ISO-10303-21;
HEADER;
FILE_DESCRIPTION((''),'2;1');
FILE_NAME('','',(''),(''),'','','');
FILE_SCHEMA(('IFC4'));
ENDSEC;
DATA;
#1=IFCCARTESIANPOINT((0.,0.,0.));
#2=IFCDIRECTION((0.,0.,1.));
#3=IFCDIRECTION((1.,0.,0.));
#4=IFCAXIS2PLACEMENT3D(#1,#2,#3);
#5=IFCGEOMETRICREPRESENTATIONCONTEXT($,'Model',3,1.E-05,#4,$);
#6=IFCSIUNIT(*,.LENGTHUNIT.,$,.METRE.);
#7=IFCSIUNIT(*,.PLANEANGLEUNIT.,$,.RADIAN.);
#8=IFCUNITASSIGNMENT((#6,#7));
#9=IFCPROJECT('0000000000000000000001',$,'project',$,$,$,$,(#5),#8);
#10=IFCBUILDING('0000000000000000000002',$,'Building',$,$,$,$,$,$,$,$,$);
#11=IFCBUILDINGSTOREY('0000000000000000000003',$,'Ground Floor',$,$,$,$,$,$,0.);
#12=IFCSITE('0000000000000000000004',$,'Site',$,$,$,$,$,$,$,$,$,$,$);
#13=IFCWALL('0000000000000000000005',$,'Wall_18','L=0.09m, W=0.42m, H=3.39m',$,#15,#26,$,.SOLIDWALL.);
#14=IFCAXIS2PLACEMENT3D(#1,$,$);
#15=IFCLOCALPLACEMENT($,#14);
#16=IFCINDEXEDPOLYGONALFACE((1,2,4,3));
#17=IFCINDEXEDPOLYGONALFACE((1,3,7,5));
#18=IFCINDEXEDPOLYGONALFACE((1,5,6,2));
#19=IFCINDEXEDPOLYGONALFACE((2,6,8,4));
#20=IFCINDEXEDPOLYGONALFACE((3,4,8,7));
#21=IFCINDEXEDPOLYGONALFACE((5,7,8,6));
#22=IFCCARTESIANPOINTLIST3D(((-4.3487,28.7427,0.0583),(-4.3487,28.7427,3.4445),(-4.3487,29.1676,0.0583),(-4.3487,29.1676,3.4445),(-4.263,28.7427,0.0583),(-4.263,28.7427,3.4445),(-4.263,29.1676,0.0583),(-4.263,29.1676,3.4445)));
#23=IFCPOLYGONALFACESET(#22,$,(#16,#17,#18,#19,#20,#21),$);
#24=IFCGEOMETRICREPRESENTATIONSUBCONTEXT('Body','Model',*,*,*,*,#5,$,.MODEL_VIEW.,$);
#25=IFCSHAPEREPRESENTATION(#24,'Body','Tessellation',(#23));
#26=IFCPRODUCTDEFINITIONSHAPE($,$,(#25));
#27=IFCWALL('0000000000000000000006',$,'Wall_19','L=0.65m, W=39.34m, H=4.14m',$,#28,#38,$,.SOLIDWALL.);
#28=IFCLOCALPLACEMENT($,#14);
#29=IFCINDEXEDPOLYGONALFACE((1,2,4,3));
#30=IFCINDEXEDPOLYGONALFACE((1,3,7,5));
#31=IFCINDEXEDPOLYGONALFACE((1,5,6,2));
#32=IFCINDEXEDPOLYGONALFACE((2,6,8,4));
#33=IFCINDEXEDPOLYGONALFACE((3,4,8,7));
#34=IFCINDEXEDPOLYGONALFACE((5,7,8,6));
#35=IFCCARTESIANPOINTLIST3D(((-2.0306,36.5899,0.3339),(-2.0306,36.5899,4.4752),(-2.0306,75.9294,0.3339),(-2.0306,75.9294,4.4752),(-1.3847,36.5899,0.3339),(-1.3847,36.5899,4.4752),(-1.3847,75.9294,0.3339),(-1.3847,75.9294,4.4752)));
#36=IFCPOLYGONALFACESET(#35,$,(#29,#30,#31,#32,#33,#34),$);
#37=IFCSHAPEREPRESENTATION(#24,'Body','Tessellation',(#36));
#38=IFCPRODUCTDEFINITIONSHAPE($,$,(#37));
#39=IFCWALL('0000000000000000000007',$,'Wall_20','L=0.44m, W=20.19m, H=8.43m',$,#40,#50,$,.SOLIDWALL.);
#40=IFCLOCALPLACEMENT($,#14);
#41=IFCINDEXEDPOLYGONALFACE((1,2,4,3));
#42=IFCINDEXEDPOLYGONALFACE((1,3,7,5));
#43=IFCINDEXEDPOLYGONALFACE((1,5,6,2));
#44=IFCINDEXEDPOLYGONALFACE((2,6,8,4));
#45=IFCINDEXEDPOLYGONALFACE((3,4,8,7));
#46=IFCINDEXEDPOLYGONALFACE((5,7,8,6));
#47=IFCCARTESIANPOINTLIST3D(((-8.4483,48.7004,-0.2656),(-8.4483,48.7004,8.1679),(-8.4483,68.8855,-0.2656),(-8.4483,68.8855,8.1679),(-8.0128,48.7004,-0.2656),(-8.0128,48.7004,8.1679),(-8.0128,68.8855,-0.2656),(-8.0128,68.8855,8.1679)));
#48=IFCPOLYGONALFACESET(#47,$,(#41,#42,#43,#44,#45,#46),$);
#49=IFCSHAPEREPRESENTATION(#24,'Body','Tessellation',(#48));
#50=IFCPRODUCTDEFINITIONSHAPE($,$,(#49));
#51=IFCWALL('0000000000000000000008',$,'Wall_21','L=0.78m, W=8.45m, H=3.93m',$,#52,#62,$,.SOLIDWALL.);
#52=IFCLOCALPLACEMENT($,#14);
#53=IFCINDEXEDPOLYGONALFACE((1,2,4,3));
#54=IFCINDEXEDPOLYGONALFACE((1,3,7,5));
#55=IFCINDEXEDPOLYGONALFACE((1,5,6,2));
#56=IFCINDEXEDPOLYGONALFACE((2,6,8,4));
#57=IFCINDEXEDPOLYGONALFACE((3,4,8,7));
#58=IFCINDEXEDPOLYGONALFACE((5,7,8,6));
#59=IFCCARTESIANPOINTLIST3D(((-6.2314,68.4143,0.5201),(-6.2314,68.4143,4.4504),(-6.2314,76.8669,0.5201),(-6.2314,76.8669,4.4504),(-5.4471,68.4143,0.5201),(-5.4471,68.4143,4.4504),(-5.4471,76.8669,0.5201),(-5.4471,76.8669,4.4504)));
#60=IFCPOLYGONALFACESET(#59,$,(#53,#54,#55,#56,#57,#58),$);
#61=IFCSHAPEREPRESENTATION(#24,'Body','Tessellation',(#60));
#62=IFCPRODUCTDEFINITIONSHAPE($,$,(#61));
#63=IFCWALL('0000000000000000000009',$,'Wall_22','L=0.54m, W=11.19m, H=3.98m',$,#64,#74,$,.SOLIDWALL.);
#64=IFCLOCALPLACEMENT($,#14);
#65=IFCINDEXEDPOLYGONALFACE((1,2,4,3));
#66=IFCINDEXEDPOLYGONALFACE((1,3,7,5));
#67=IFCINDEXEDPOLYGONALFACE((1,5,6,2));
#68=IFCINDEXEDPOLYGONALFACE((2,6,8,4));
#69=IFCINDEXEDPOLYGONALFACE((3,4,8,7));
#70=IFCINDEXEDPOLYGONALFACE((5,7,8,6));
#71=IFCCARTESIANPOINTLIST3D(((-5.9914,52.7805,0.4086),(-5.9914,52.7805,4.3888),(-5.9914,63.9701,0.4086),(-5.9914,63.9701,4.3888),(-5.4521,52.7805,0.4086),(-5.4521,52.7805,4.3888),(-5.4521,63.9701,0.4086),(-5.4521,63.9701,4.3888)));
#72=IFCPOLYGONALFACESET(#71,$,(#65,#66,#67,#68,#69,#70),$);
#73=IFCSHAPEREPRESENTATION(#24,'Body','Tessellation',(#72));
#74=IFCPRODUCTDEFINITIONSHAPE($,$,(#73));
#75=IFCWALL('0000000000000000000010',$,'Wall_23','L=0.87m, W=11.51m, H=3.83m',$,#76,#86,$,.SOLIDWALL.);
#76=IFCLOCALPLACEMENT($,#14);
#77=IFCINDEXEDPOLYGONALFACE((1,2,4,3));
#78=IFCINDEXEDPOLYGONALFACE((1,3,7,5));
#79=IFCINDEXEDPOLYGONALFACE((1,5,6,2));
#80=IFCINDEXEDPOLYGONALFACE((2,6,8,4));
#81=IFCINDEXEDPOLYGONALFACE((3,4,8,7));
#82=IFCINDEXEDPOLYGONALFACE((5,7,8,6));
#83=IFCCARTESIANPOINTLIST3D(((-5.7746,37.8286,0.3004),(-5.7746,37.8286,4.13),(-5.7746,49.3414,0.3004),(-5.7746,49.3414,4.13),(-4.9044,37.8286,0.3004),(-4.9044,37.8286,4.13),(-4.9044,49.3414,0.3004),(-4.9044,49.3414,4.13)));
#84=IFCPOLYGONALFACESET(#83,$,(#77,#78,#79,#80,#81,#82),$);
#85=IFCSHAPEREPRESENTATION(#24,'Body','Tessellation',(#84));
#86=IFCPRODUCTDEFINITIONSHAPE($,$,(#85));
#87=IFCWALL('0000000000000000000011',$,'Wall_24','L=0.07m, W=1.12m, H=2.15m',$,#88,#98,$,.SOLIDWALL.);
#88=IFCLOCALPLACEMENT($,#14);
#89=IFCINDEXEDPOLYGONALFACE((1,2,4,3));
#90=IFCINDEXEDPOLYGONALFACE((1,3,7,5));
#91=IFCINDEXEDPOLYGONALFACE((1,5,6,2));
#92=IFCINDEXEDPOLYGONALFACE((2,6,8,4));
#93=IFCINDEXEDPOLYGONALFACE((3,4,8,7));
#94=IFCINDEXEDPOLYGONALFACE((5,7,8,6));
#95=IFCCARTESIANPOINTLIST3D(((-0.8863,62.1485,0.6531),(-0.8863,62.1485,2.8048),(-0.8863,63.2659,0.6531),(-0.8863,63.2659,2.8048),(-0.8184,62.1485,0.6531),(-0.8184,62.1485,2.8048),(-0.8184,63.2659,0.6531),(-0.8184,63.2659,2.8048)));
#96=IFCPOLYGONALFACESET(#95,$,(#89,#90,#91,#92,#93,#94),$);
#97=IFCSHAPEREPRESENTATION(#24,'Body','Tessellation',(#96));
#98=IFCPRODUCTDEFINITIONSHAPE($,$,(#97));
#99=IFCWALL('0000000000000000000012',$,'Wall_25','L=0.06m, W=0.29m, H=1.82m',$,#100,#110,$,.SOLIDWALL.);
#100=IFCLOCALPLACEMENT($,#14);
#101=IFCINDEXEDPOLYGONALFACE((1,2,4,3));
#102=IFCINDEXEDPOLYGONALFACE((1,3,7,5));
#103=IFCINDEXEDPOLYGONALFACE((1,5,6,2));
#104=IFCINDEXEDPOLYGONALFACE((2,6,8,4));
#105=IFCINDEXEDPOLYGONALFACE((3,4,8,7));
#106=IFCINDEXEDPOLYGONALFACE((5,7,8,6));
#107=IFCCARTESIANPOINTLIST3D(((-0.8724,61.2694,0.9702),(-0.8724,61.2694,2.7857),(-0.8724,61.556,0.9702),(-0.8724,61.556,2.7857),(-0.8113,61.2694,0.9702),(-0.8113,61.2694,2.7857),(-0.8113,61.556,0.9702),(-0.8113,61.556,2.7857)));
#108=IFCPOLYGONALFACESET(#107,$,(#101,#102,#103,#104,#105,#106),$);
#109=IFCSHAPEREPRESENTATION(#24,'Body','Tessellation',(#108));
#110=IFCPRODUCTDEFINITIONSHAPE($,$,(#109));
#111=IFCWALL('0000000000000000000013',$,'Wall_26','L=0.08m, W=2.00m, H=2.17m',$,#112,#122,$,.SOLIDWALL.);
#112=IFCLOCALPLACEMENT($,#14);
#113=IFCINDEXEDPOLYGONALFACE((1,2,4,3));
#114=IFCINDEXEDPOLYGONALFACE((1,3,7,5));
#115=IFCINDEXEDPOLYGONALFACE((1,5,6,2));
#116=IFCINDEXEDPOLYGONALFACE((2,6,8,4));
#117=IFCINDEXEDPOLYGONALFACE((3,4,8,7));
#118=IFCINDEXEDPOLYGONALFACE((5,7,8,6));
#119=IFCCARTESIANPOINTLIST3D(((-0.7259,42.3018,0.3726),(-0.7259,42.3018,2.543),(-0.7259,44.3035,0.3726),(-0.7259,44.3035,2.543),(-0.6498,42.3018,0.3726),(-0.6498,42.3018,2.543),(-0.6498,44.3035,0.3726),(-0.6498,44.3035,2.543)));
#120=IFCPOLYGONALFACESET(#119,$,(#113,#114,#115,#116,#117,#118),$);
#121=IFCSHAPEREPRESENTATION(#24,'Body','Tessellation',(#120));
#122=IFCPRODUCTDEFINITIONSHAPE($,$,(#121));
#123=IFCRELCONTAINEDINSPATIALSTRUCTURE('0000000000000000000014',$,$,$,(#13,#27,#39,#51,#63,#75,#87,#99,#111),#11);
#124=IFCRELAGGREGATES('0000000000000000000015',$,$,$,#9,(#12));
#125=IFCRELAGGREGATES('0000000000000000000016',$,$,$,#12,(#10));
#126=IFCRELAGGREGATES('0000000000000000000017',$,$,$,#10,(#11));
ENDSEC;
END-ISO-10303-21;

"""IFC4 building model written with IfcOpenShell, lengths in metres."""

from ifc_helpers import new_model, si_unit, frame, origin_with_axes, origin_2d, context, subcontext, project, spatial, rectangle, extrude, element, save


model = new_model("IFC4")

# Units and contexts
model_context = context("Model", 3, precision=1e-05, world=origin_with_axes())
body_context = subcontext(model_context, "Body", "Model", "MODEL_VIEW")
ifc_project = project(units=[si_unit("LENGTHUNIT", "METRE"), si_unit("PLANEANGLEUNIT", "RADIAN")], contexts=[model_context])

# Site, building, storey
site = spatial("IfcSite", under=ifc_project, Name="Site")
building = spatial("IfcBuilding", under=site, Name="Building")
storey = spatial("IfcBuildingStorey", under=building, Name="Ground Floor", Elevation=0.0)

# Walls
element("IfcWall", 1, inside=storey, Name="Wall_18", Description="L=0.09m, W=0.42m, H=3.39m", PredefinedType="SOLIDWALL", context=body_context, shape_type="SweptSolid", body=[
    extrude(rectangle(XDim=0.0857, YDim=0.4249, at=origin_2d()), frame((-4.3058, 28.9551, 0.0583), z_axis=(0.0, 0.0, 1.0), x_axis=(1.0, 0.0, 0.0)), (0.0, 0.0, 1.0), 3.3862),
])
element("IfcWall", 2, inside=storey, Name="Wall_19", Description="L=0.65m, W=39.34m, H=4.14m", PredefinedType="SOLIDWALL", context=body_context, shape_type="SweptSolid", body=[
    extrude(rectangle(XDim=0.6459, YDim=39.3394, at=origin_2d()), frame((-1.7077, 56.2597, 0.3339), z_axis=(0.0, 0.0, 1.0), x_axis=(1.0, 0.0, 0.0)), (0.0, 0.0, 1.0), 4.1413),
])
element("IfcWall", 3, inside=storey, Name="Wall_20", Description="L=0.44m, W=20.19m, H=8.43m", PredefinedType="SOLIDWALL", context=body_context, shape_type="SweptSolid", body=[
    extrude(rectangle(XDim=0.4355, YDim=20.1851, at=origin_2d()), frame((-8.2305, 58.7929, -0.2656), z_axis=(0.0, 0.0, 1.0), x_axis=(1.0, 0.0, 0.0)), (0.0, 0.0, 1.0), 8.4335),
])
element("IfcWall", 4, inside=storey, Name="Wall_21", Description="L=0.78m, W=8.45m, H=3.93m", PredefinedType="SOLIDWALL", context=body_context, shape_type="SweptSolid", body=[
    extrude(rectangle(XDim=0.7843, YDim=8.4526, at=origin_2d()), frame((-5.8392, 72.6406, 0.5201), z_axis=(0.0, 0.0, 1.0), x_axis=(1.0, 0.0, 0.0)), (0.0, 0.0, 1.0), 3.9304),
])
element("IfcWall", 5, inside=storey, Name="Wall_22", Description="L=0.54m, W=11.19m, H=3.98m", PredefinedType="SOLIDWALL", context=body_context, shape_type="SweptSolid", body=[
    extrude(rectangle(XDim=0.5393, YDim=11.1896, at=origin_2d()), frame((-5.7218, 58.3753, 0.4086), z_axis=(0.0, 0.0, 1.0), x_axis=(1.0, 0.0, 0.0)), (0.0, 0.0, 1.0), 3.9801),
])
element("IfcWall", 6, inside=storey, Name="Wall_23", Description="L=0.87m, W=11.51m, H=3.83m", PredefinedType="SOLIDWALL", context=body_context, shape_type="SweptSolid", body=[
    extrude(rectangle(XDim=0.8702, YDim=11.5128, at=origin_2d()), frame((-5.3395, 43.585, 0.3004), z_axis=(0.0, 0.0, 1.0), x_axis=(1.0, 0.0, 0.0)), (0.0, 0.0, 1.0), 3.8297),
])
element("IfcWall", 7, inside=storey, Name="Wall_24", Description="L=0.07m, W=1.12m, H=2.15m", PredefinedType="SOLIDWALL", context=body_context, shape_type="SweptSolid", body=[
    extrude(rectangle(XDim=0.068, YDim=1.1173, at=origin_2d()), frame((-0.8524, 62.7072, 0.6531), z_axis=(0.0, 0.0, 1.0), x_axis=(1.0, 0.0, 0.0)), (0.0, 0.0, 1.0), 2.1517),
])
element("IfcWall", 8, inside=storey, Name="Wall_25", Description="L=0.06m, W=0.29m, H=1.82m", PredefinedType="SOLIDWALL", context=body_context, shape_type="SweptSolid", body=[
    extrude(rectangle(XDim=0.0611, YDim=0.2866, at=origin_2d()), frame((-0.8419, 61.4127, 0.9702), z_axis=(0.0, 0.0, 1.0), x_axis=(1.0, 0.0, 0.0)), (0.0, 0.0, 1.0), 1.8156),
])
element("IfcWall", 9, inside=storey, Name="Wall_26", Description="L=0.08m, W=2.00m, H=2.17m", PredefinedType="SOLIDWALL", context=body_context, shape_type="SweptSolid", body=[
    extrude(rectangle(XDim=0.0761, YDim=2.0017, at=origin_2d()), frame((-0.6879, 43.3026, 0.3726), z_axis=(0.0, 0.0, 1.0), x_axis=(1.0, 0.0, 0.0)), (0.0, 0.0, 1.0), 2.1704),
])

save(model, "model.ifc")
